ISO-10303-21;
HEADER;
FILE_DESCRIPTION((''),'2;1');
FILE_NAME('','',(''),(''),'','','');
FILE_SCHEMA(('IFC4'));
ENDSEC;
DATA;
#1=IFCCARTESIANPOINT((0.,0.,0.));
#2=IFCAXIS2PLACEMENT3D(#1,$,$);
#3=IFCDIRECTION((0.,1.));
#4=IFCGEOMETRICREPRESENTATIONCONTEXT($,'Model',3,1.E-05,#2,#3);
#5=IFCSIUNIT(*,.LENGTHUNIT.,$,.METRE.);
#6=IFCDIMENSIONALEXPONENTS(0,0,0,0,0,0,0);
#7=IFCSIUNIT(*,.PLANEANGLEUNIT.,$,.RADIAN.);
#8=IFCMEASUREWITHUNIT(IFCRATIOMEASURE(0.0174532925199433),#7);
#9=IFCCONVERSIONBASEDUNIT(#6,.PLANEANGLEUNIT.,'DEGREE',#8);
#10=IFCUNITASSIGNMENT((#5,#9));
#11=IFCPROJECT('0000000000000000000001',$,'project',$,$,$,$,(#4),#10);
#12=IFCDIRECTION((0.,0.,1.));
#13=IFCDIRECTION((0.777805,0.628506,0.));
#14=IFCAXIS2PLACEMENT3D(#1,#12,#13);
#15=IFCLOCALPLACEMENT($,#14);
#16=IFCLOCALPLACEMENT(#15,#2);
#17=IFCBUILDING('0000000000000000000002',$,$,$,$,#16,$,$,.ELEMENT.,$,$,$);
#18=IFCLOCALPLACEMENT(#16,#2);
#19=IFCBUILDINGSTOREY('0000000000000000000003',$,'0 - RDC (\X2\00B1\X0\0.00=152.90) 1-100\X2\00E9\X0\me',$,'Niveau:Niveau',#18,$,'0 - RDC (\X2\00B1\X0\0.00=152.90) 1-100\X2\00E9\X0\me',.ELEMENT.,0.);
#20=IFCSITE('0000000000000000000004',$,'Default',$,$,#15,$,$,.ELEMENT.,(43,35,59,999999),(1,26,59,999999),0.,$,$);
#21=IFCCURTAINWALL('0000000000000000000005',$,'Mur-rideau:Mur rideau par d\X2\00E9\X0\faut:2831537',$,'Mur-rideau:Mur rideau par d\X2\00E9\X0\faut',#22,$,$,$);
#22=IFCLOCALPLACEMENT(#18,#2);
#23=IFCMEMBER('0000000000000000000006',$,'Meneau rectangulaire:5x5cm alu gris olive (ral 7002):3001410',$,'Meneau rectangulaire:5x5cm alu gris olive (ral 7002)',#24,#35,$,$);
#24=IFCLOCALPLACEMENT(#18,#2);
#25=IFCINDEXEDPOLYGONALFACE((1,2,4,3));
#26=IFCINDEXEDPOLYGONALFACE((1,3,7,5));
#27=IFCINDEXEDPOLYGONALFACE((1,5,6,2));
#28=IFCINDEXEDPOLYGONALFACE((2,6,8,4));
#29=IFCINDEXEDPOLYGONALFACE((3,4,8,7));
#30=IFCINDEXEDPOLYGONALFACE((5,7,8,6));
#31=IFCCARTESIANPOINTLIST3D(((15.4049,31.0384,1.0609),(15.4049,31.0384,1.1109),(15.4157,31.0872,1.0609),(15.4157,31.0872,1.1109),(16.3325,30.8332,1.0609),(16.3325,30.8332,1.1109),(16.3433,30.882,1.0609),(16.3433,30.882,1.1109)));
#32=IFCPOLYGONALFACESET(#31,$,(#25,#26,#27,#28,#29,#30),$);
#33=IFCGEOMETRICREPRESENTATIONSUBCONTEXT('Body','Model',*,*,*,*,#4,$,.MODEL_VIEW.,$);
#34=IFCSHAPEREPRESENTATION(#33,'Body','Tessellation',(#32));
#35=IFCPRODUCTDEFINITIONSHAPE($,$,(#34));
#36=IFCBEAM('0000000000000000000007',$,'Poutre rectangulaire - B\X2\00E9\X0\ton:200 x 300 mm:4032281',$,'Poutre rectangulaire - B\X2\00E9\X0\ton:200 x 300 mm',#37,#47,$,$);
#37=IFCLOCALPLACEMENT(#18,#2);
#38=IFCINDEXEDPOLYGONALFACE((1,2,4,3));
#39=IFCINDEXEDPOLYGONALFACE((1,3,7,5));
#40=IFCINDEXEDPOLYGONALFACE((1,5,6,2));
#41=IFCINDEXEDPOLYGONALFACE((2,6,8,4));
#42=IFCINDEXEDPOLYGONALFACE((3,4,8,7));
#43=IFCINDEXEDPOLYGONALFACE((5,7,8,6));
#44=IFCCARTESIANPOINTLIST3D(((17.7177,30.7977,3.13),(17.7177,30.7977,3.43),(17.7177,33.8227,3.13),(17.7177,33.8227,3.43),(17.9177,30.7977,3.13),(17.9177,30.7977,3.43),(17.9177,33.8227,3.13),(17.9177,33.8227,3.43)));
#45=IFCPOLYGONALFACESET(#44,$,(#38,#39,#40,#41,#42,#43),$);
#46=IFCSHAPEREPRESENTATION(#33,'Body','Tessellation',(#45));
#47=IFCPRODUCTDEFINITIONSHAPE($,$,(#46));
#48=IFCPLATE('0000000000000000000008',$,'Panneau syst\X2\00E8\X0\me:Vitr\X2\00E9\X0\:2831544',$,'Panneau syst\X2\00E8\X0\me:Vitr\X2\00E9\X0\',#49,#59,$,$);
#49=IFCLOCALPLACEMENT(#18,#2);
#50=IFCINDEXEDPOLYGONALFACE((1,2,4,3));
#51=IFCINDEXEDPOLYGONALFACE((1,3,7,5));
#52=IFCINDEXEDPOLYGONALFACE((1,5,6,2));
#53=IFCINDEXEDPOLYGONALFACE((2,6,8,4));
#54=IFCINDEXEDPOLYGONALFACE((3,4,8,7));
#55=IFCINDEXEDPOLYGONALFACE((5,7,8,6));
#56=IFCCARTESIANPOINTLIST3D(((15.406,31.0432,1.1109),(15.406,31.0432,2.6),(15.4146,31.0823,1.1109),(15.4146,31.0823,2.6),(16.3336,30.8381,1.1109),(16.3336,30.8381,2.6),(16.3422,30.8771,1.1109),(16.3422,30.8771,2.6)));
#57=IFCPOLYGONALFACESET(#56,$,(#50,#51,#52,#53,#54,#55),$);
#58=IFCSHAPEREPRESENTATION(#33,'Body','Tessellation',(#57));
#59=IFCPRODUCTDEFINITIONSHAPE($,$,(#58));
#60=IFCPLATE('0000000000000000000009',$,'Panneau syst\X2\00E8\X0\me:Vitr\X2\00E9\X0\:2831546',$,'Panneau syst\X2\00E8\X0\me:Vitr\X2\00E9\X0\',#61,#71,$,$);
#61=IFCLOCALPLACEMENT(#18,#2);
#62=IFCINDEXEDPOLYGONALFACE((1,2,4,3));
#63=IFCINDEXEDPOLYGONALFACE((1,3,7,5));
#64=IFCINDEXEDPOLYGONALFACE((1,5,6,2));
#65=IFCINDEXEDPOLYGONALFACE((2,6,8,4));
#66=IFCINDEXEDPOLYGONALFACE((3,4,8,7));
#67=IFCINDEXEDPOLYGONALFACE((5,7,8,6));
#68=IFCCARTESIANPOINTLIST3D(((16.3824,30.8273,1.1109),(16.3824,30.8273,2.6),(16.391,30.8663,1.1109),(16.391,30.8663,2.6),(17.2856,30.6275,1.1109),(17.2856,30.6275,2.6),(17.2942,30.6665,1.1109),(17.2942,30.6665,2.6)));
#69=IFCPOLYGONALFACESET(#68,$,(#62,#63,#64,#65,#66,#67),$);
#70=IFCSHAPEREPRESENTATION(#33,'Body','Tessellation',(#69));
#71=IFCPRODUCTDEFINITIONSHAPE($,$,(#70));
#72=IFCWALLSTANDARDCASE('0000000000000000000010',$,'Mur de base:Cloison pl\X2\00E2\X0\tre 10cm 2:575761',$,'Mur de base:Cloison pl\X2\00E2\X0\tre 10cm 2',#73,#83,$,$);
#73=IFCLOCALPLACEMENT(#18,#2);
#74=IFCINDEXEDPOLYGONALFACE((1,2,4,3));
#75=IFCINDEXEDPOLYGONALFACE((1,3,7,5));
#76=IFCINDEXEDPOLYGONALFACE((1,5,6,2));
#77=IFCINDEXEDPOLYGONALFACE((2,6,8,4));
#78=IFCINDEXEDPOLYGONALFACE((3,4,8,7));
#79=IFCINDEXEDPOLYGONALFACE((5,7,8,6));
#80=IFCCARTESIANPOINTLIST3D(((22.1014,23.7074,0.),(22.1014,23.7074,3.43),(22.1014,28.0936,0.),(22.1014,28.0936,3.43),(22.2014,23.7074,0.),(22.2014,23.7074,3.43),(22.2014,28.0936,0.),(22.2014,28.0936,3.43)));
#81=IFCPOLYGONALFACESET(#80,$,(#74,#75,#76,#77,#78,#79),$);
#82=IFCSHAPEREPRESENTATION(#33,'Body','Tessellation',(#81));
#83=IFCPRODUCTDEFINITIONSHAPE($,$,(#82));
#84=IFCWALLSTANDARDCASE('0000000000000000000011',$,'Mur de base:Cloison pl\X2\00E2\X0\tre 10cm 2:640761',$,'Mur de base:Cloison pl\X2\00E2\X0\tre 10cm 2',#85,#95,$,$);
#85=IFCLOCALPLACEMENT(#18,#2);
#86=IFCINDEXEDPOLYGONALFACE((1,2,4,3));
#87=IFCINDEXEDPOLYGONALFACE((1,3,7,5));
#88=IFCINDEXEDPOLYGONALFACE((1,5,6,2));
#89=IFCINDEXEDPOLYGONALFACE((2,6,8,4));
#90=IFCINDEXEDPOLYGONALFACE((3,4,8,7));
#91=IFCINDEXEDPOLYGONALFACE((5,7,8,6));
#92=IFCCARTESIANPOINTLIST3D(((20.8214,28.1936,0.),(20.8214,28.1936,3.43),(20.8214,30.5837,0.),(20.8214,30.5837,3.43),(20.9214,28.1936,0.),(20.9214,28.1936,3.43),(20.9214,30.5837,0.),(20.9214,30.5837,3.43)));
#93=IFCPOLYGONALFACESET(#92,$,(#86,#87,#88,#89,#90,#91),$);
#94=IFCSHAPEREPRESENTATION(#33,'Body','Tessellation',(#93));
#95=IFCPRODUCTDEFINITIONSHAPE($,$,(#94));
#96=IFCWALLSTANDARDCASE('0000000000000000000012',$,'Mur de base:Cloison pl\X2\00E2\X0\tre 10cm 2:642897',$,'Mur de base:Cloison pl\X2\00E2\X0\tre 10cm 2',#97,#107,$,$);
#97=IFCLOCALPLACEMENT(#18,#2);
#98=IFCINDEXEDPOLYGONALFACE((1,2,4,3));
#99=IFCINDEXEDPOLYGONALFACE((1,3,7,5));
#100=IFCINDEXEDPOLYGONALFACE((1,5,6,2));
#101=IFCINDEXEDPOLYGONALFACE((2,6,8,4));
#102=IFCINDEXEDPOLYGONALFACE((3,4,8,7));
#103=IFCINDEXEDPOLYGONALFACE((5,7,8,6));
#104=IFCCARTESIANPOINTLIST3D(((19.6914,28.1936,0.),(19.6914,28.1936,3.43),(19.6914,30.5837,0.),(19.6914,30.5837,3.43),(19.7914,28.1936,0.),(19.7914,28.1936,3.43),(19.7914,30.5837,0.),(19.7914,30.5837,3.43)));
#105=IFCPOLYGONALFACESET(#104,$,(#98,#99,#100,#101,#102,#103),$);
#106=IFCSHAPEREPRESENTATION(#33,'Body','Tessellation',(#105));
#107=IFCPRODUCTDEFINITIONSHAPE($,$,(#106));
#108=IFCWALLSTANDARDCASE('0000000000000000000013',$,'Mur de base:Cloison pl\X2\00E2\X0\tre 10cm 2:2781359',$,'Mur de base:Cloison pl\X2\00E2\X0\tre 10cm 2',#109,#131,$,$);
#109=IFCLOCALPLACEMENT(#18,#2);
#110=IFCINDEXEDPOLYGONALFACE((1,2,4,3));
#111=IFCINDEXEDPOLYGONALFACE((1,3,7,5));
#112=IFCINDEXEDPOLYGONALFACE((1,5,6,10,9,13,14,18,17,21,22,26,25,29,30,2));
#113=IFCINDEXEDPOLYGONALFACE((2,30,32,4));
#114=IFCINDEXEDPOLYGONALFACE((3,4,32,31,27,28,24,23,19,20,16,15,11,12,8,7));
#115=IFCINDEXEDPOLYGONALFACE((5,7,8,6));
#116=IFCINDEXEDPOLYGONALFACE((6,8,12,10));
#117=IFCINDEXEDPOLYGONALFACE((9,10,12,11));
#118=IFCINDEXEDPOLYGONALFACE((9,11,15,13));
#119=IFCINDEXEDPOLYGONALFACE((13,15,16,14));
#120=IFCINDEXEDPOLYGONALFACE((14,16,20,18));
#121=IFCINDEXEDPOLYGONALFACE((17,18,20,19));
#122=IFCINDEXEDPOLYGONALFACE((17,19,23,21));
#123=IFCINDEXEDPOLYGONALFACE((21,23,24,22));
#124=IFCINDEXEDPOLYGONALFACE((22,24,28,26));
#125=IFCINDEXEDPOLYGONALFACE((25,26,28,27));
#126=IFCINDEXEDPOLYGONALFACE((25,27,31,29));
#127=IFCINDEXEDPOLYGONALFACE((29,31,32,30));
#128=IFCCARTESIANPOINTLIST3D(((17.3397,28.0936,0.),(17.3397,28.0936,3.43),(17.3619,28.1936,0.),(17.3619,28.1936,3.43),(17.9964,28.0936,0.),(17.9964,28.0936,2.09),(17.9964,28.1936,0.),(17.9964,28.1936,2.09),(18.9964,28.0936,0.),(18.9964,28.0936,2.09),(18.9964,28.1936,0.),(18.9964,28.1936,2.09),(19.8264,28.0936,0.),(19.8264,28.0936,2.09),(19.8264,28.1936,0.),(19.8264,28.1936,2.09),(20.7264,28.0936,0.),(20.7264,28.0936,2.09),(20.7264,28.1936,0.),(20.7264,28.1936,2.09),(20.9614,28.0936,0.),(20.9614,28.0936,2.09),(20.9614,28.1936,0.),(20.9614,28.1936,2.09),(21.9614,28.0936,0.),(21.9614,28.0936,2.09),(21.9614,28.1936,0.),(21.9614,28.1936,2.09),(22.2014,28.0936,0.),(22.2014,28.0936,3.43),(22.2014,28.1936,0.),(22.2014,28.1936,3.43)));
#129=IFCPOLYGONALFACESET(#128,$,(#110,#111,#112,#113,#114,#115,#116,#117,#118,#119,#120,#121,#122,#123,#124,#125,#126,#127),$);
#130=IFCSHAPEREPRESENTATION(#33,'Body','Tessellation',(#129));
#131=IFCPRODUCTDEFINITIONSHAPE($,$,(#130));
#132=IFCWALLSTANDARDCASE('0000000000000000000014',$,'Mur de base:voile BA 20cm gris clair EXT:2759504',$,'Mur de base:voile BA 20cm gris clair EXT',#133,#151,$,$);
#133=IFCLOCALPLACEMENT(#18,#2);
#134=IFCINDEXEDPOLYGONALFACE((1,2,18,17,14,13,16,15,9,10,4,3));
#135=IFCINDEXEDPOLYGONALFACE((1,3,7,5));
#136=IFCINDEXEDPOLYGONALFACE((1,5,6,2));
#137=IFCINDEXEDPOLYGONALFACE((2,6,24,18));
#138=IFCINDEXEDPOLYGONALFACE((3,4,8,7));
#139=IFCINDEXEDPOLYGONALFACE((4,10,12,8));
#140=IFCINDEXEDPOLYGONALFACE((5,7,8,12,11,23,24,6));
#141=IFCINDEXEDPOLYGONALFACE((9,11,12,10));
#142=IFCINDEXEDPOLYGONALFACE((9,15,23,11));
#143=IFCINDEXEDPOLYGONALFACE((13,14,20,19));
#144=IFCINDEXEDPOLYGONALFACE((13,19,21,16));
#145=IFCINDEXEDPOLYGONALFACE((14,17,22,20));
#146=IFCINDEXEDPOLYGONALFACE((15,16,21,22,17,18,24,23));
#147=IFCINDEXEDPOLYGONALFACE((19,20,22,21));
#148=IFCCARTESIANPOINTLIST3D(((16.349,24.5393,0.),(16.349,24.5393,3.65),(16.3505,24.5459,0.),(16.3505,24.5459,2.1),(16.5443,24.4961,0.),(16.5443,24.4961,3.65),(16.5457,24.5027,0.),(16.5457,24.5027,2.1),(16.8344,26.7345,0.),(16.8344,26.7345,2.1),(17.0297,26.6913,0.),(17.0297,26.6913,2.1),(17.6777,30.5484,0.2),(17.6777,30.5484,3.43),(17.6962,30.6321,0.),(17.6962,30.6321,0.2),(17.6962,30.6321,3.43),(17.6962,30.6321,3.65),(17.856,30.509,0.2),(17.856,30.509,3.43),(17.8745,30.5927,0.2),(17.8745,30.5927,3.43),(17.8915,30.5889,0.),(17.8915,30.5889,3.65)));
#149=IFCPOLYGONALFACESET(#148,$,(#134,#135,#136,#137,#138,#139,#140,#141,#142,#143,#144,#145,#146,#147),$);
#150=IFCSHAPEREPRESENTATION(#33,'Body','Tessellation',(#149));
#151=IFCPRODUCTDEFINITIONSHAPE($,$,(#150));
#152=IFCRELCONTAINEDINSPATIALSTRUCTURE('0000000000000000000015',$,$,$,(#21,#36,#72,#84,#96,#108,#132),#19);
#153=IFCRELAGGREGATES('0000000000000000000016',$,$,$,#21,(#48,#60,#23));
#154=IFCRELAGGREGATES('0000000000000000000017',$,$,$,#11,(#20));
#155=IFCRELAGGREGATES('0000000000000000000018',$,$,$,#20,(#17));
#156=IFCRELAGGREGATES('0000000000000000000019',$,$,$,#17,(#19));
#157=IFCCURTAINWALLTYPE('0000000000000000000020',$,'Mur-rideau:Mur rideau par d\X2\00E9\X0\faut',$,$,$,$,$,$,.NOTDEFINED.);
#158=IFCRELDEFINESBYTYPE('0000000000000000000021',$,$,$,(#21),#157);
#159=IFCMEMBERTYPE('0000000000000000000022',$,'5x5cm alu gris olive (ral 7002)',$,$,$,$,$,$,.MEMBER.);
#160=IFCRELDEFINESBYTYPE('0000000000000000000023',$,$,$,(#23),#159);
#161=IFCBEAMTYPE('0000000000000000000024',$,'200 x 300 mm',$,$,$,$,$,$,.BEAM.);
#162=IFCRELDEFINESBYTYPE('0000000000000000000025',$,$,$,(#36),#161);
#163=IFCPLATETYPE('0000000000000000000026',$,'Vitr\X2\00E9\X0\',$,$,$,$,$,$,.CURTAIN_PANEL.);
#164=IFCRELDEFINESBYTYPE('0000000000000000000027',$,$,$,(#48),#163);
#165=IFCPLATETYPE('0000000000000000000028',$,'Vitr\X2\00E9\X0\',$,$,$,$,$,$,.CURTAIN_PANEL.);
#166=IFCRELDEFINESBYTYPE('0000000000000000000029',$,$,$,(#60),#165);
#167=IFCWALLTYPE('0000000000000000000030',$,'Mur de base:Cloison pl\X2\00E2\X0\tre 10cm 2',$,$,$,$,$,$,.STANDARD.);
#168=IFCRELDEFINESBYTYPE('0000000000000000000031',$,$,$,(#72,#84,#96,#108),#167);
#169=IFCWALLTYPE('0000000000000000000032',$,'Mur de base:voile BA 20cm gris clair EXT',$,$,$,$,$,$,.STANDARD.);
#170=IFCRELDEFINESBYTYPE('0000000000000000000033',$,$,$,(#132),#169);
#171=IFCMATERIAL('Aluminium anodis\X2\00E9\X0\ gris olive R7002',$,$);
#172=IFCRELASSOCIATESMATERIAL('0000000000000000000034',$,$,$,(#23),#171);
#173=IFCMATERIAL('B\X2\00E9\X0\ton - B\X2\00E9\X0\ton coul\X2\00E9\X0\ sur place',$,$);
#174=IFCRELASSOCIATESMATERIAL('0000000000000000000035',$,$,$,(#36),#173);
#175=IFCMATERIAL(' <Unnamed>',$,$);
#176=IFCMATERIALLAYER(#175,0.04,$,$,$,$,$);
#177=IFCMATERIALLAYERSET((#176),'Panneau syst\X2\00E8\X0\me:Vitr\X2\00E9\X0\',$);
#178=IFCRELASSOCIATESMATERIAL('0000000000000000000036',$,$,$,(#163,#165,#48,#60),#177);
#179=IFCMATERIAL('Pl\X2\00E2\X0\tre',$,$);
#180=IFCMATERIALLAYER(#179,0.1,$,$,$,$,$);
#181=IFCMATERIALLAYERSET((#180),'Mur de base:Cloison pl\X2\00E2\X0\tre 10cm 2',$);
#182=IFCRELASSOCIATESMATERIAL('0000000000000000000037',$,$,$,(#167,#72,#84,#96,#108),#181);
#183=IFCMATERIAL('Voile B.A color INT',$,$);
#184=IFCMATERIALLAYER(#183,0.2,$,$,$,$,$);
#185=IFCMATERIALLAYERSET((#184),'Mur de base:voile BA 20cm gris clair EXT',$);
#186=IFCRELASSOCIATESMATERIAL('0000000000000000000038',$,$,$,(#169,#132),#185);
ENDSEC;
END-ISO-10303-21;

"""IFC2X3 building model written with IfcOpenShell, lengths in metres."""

from ifc_helpers import new_model, entity, si_unit, converted_unit, direction, frame, frame_2d, origin, origin_2d_with_axis, place, context, subcontext, project, spatial, polyline, rectangle, outline, extrude, source, transform, mapped, material, layer, layer_set, layer_usage, type_object, type_shapes, element, aggregate, save


model = new_model("IFC2X3")

# Units and contexts
model_context = context("Model", 3, precision=1e-05, world=origin(), true_north=direction((0.0, 1.0)))
body_context = subcontext(model_context, "Body", "Model", "MODEL_VIEW")
ifc_project = project(units=[si_unit("LENGTHUNIT", "METRE"), converted_unit("PLANEANGLEUNIT", "DEGREE", entity("IfcRatioMeasure", 0.0174532925199433), si_unit("PLANEANGLEUNIT", "RADIAN"), dimensions=[0, 0, 0, 0, 0, 0, 0])], contexts=[model_context])

# Site, building, storey
site_placement = place(None, frame((0.0, 0.0, 0.0), z_axis=(0.0, 0.0, 1.0), x_axis=(0.777805, 0.628506, 0.0)))
site = spatial("IfcSite", under=ifc_project, at=site_placement, Name="Default", CompositionType="ELEMENT", RefLatitude=(43, 35, 59, 999999), RefLongitude=(1, 26, 59, 999999), RefElevation=0.0)
building_placement = place(site_placement, origin())
building = spatial("IfcBuilding", under=site, at=building_placement, CompositionType="ELEMENT")
storey_placement = place(building_placement, origin())
storey = spatial("IfcBuildingStorey", under=building, at=storey_placement, Name="0 - RDC (±0.00=152.90) 1-100éme", ObjectType="Niveau:Niveau", LongName="0 - RDC (±0.00=152.90) 1-100éme", CompositionType="ELEMENT", Elevation=0.0)

# Curtain wall, member
curtain_wall_type = type_object("IfcCurtainWallType", Name="Mur-rideau:Mur rideau par défaut", PredefinedType="NOTDEFINED")
curtain_wall_placement = place(storey_placement, origin())
curtain_wall = element("IfcCurtainWall", 1, at=curtain_wall_placement, inside=storey, type_object=curtain_wall_type, Name="Mur-rideau:Mur rideau par défaut:2831537", ObjectType="Mur-rideau:Mur rideau par défaut")
ifc_material_1 = material(Name="Aluminium anodisé gris olive R7002")
member_type_1 = type_object("IfcMemberType", Name="5x5cm alu gris olive (ral 7002)", PredefinedType="MEMBER")
shared_shape_1 = source(origin(), body_context, "Body", "SweptSolid", [
    extrude(rectangle(XDim=0.05, YDim=0.05, at=origin_2d_with_axis()), frame((-0.025, 0.0, -0.95), z_axis=(0.0, 0.0, 1.0), x_axis=(0.0, -1.0, 0.0)), (0.0, 0.0, 1.0), 0.95),
])
type_shapes(member_type_1, [shared_shape_1])
member_1_placement = place(storey_placement, frame((15.4103, 31.0628, 1.0609), z_axis=(-0.976397, 0.215985, 0.0), x_axis=(0.0, 0.0, -1.0)))
member_1 = element("IfcMember", 2, at=member_1_placement, type_object=member_type_1, material=ifc_material_1, Name="Meneau rectangulaire:5x5cm alu gris olive (ral 7002):3001410", ObjectType="Meneau rectangulaire:5x5cm alu gris olive (ral 7002)", context=body_context, shape_type="MappedRepresentation", body=[
    mapped(shared_shape_1, transform((0.0, 0.0, 0.0), scale=1.0)),
])

# Beam
ifc_material_2 = material(Name="Béton - Béton coulé sur place")
beam_type = type_object("IfcBeamType", Name="200 x 300 mm", PredefinedType="BEAM")
beam_placement = place(storey_placement, frame((17.8177, 33.8227, 3.43), z_axis=(0.0, 0.0, 1.0), x_axis=(0.0, -1.0, 0.0)))
element("IfcBeam", 3, at=beam_placement, inside=storey, type_object=beam_type, material=ifc_material_2, Name="Poutre rectangulaire - Béton:200 x 300 mm:4032281", ObjectType="Poutre rectangulaire - Béton:200 x 300 mm", context=body_context, shape_type="SweptSolid", body=[
    extrude(rectangle(XDim=0.3, YDim=0.2, at=frame_2d((0.0, 0.0), x_axis=(1.0, 0.0))), frame((0.0, 0.0, -0.15), z_axis=(1.0, 0.0, 0.0), x_axis=(0.0, 0.0, -1.0)), (0.0, 0.0, 1.0), 3.025),
])

# Plates
ifc_material_3 = material(Name=" <Unnamed>")
ifc_layer_1 = layer(ifc_material_3, 0.04)
ifc_layer_set_1 = layer_set([ifc_layer_1], Name="Panneau système:Vitré")
ifc_layer_usage_1 = layer_usage(ifc_layer_set_1, "AXIS3", "POSITIVE", 0.0)
plate_type_1 = type_object("IfcPlateType", Name="Vitré", PredefinedType="CURTAIN_PANEL", material=ifc_layer_set_1)
shared_shape_2 = source(origin(), body_context, "Body", "SweptSolid", [
    extrude(rectangle(XDim=0.04, YDim=0.95, at=frame_2d((0.0, 0.0), x_axis=(1.0, 0.0))), frame((0.0, 0.0, 0.0), z_axis=(0.0, 0.0, 1.0), x_axis=(0.0, 1.0, 0.0)), (0.0, 0.0, 1.0), 1.4891),
])
type_shapes(plate_type_1, [shared_shape_2])
plate_1_placement = place(curtain_wall_placement, frame((15.8741, 30.9602, 1.1109), z_axis=(0.0, 0.0, 1.0), x_axis=(0.976397, -0.215985, 0.0)))
plate_1 = element("IfcPlate", 4, at=plate_1_placement, type_object=plate_type_1, material=ifc_layer_usage_1, Name="Panneau système:Vitré:2831544", ObjectType="Panneau système:Vitré", context=body_context, shape_type="MappedRepresentation", body=[
    mapped(shared_shape_2, transform((0.0, 0.0, 0.0), scale=1.0)),
])
ifc_layer_usage_2 = layer_usage(ifc_layer_set_1, "AXIS3", "POSITIVE", 0.0)
plate_type_2 = type_object("IfcPlateType", Name="Vitré", PredefinedType="CURTAIN_PANEL", material=ifc_layer_set_1)
shared_shape_3 = source(origin(), body_context, "Body", "SweptSolid", [
    extrude(rectangle(XDim=0.04, YDim=0.925, at=frame_2d((0.0, 0.0), x_axis=(1.0, 0.0))), frame((0.0, 0.0, 0.0), z_axis=(0.0, 0.0, 1.0), x_axis=(0.0, 1.0, 0.0)), (0.0, 0.0, 1.0), 1.4891),
])
type_shapes(plate_type_2, [shared_shape_3])
plate_2_placement = place(curtain_wall_placement, frame((16.8383, 30.7469, 1.1109), z_axis=(0.0, 0.0, 1.0), x_axis=(0.976397, -0.215985, 0.0)))
plate_2 = element("IfcPlate", 5, at=plate_2_placement, type_object=plate_type_2, material=ifc_layer_usage_2, Name="Panneau système:Vitré:2831546", ObjectType="Panneau système:Vitré", context=body_context, shape_type="MappedRepresentation", body=[
    mapped(shared_shape_3, transform((0.0, 0.0, 0.0), scale=1.0)),
])
aggregate(curtain_wall, [plate_1, plate_2, member_1])

# Walls
ifc_material_4 = material(Name="Plâtre")
ifc_layer_2 = layer(ifc_material_4, 0.1)
ifc_layer_set_2 = layer_set([ifc_layer_2], Name="Mur de base:Cloison plâtre 10cm 2")
ifc_layer_usage_3 = layer_usage(ifc_layer_set_2, "AXIS2", "NEGATIVE", 0.05)
wall_type_1 = type_object("IfcWallType", Name="Mur de base:Cloison plâtre 10cm 2", PredefinedType="STANDARD", material=ifc_layer_set_2)
wall_1_placement = place(storey_placement, frame((22.1514, 28.0936, 0.0), z_axis=(0.0, 0.0, 1.0), x_axis=(0.0, -1.0, 0.0)))
element("IfcWallStandardCase", 6, at=wall_1_placement, inside=storey, type_object=wall_type_1, material=ifc_layer_usage_3, Name="Mur de base:Cloison plâtre 10cm 2:575761", ObjectType="Mur de base:Cloison plâtre 10cm 2", context=body_context, shape_type="SweptSolid", body=[
    extrude(rectangle(XDim=4.3862, YDim=0.1, at=frame_2d((2.1931, 0.0), x_axis=(-1.0, 0.0))), origin(), (0.0, 0.0, 1.0), 3.43),
])
ifc_layer_usage_4 = layer_usage(ifc_layer_set_2, "AXIS2", "NEGATIVE", 0.05)
wall_2_placement = place(storey_placement, frame((20.8714, 30.5837, 0.0), z_axis=(0.0, 0.0, 1.0), x_axis=(0.0, -1.0, 0.0)))
element("IfcWallStandardCase", 7, at=wall_2_placement, inside=storey, type_object=wall_type_1, material=ifc_layer_usage_4, Name="Mur de base:Cloison plâtre 10cm 2:640761", ObjectType="Mur de base:Cloison plâtre 10cm 2", context=body_context, shape_type="SweptSolid", body=[
    extrude(rectangle(XDim=2.3901, YDim=0.1, at=frame_2d((1.195, 0.0), x_axis=(-1.0, 0.0))), origin(), (0.0, 0.0, 1.0), 3.43),
])
ifc_layer_usage_5 = layer_usage(ifc_layer_set_2, "AXIS2", "NEGATIVE", 0.05)
wall_3_placement = place(storey_placement, frame((19.7414, 30.5837, 0.0), z_axis=(0.0, 0.0, 1.0), x_axis=(0.0, -1.0, 0.0)))
element("IfcWallStandardCase", 8, at=wall_3_placement, inside=storey, type_object=wall_type_1, material=ifc_layer_usage_5, Name="Mur de base:Cloison plâtre 10cm 2:642897", ObjectType="Mur de base:Cloison plâtre 10cm 2", context=body_context, shape_type="SweptSolid", body=[
    extrude(rectangle(XDim=2.3901, YDim=0.1, at=frame_2d((1.195, 0.0), x_axis=(-1.0, 0.0))), origin(), (0.0, 0.0, 1.0), 3.43),
])

# Walls, openings
ifc_layer_usage_6 = layer_usage(ifc_layer_set_2, "AXIS2", "NEGATIVE", 0.05)
wall_4_placement = place(storey_placement, frame((22.2014, 28.1436, 0.0), z_axis=(0.0, 0.0, 1.0), x_axis=(-1.0, 0.0, 0.0)))
wall_4 = element("IfcWallStandardCase", 9, at=wall_4_placement, inside=storey, type_object=wall_type_1, material=ifc_layer_usage_6, Name="Mur de base:Cloison plâtre 10cm 2:2781359", ObjectType="Mur de base:Cloison plâtre 10cm 2", context=body_context, shape_type="SweptSolid", body=[
    extrude(outline(polyline([(0.0, -0.05), (1.28, -0.05), (1.38, -0.05), (2.41, -0.05), (2.51, -0.05), (4.8395, -0.05), (4.8617, 0.05), (4.5071, 0.05), (4.4071, 0.05), (0.1, 0.05), (0.0, 0.05), (0.0, -0.05)])), origin(), (0.0, 0.0, 1.0), 3.43),
])
opening_1_placement = place(wall_4_placement, frame((3.205, -0.05, 0.0)))
element("IfcOpeningElement", 10, at=opening_1_placement, cuts=wall_4, ObjectType="Opening", context=body_context, shape_type="SweptSolid", body=[
    extrude(rectangle(XDim=2.09, YDim=1.0, at=frame_2d((1.045, 0.5), x_axis=(1.0, 0.0))), frame((0.0, 0.0, 0.0), z_axis=(0.0, 1.0, 0.0), x_axis=(0.0, 0.0, 1.0)), (0.0, 0.0, 1.0), 0.1),
])
opening_2_placement = place(wall_4_placement, frame((1.24, 0.05, 0.0)))
element("IfcOpeningElement", 11, at=opening_2_placement, cuts=wall_4, ObjectType="Opening", context=body_context, shape_type="SweptSolid", body=[
    extrude(rectangle(XDim=2.09, YDim=1.0, at=frame_2d((1.045, 0.5), x_axis=(1.0, 0.0))), frame((0.0, 0.0, 0.0), z_axis=(0.0, -1.0, 0.0), x_axis=(0.0, 0.0, 1.0)), (0.0, 0.0, 1.0), 0.1),
])
opening_3_placement = place(wall_4_placement, frame((1.475, -0.05, 0.0)))
element("IfcOpeningElement", 12, at=opening_3_placement, cuts=wall_4, ObjectType="Opening", context=body_context, shape_type="SweptSolid", body=[
    extrude(rectangle(XDim=2.09, YDim=0.9, at=frame_2d((1.045, 0.45), x_axis=(1.0, 0.0))), frame((0.0, 0.0, 0.0), z_axis=(0.0, 1.0, 0.0), x_axis=(0.0, 0.0, 1.0)), (0.0, 0.0, 1.0), 0.1),
])
ifc_material_5 = material(Name="Voile B.A color INT")
ifc_layer_3 = layer(ifc_material_5, 0.2)
ifc_layer_set_3 = layer_set([ifc_layer_3], Name="Mur de base:voile BA 20cm gris clair EXT")
ifc_layer_usage_7 = layer_usage(ifc_layer_set_3, "AXIS2", "NEGATIVE", 0.1)
wall_type_2 = type_object("IfcWallType", Name="Mur de base:voile BA 20cm gris clair EXT", PredefinedType="STANDARD", material=ifc_layer_set_3)
wall_5_placement = place(storey_placement, frame((17.7939, 30.6105, 0.0), z_axis=(0.0, 0.0, 1.0), x_axis=(-0.2159, -0.976415, 0.0)))
wall_5 = element("IfcWallStandardCase", 13, at=wall_5_placement, inside=storey, type_object=wall_type_2, material=ifc_layer_usage_7, Name="Mur de base:voile BA 20cm gris clair EXT:2759504", ObjectType="Mur de base:voile BA 20cm gris clair EXT", context=body_context, shape_type="SweptSolid", body=[
    extrude(rectangle(XDim=6.24, YDim=0.2, at=frame_2d((3.12, 0.0), x_axis=(-1.0, 0.0))), origin(), (0.0, 0.0, 1.0), 3.65),
])
opening_4_placement = place(storey_placement, frame((17.7939, 30.6105, 0.0), z_axis=(0.0, 0.0, 1.0), x_axis=(-0.2159, -0.976415, 0.0)))
element("IfcOpeningElement", 14, at=opening_4_placement, cuts=wall_5, ObjectType="Opening", context=body_context, shape_type="SweptSolid", body=[
    extrude(outline(polyline([(-0.0913, -0.0429), (0.0913, -0.0429), (0.0913, 0.0429), (-0.0913, 0.0429), (-0.0913, -0.0429)])), frame((0.0429, -0.0087, 0.2), z_axis=(0.0, 0.0, 1.0), x_axis=(0.000087, 1.0, 0.0)), (0.0, 0.0, 1.0), 3.23),
])
opening_5_placement = place(wall_5_placement, origin())
element("IfcOpeningElement", 15, at=opening_5_placement, cuts=wall_5, ObjectType="Opening", context=body_context, shape_type="SweptSolid", body=[
    extrude(rectangle(XDim=2.1, YDim=2.2414, at=origin_2d_with_axis()), frame((5.1125, -0.1, 1.05), z_axis=(0.0, 1.0, 0.0), x_axis=(0.0, 0.0, -1.0)), (0.0, 0.0, 1.0), 0.2),
])

save(model, "model.ifc")
